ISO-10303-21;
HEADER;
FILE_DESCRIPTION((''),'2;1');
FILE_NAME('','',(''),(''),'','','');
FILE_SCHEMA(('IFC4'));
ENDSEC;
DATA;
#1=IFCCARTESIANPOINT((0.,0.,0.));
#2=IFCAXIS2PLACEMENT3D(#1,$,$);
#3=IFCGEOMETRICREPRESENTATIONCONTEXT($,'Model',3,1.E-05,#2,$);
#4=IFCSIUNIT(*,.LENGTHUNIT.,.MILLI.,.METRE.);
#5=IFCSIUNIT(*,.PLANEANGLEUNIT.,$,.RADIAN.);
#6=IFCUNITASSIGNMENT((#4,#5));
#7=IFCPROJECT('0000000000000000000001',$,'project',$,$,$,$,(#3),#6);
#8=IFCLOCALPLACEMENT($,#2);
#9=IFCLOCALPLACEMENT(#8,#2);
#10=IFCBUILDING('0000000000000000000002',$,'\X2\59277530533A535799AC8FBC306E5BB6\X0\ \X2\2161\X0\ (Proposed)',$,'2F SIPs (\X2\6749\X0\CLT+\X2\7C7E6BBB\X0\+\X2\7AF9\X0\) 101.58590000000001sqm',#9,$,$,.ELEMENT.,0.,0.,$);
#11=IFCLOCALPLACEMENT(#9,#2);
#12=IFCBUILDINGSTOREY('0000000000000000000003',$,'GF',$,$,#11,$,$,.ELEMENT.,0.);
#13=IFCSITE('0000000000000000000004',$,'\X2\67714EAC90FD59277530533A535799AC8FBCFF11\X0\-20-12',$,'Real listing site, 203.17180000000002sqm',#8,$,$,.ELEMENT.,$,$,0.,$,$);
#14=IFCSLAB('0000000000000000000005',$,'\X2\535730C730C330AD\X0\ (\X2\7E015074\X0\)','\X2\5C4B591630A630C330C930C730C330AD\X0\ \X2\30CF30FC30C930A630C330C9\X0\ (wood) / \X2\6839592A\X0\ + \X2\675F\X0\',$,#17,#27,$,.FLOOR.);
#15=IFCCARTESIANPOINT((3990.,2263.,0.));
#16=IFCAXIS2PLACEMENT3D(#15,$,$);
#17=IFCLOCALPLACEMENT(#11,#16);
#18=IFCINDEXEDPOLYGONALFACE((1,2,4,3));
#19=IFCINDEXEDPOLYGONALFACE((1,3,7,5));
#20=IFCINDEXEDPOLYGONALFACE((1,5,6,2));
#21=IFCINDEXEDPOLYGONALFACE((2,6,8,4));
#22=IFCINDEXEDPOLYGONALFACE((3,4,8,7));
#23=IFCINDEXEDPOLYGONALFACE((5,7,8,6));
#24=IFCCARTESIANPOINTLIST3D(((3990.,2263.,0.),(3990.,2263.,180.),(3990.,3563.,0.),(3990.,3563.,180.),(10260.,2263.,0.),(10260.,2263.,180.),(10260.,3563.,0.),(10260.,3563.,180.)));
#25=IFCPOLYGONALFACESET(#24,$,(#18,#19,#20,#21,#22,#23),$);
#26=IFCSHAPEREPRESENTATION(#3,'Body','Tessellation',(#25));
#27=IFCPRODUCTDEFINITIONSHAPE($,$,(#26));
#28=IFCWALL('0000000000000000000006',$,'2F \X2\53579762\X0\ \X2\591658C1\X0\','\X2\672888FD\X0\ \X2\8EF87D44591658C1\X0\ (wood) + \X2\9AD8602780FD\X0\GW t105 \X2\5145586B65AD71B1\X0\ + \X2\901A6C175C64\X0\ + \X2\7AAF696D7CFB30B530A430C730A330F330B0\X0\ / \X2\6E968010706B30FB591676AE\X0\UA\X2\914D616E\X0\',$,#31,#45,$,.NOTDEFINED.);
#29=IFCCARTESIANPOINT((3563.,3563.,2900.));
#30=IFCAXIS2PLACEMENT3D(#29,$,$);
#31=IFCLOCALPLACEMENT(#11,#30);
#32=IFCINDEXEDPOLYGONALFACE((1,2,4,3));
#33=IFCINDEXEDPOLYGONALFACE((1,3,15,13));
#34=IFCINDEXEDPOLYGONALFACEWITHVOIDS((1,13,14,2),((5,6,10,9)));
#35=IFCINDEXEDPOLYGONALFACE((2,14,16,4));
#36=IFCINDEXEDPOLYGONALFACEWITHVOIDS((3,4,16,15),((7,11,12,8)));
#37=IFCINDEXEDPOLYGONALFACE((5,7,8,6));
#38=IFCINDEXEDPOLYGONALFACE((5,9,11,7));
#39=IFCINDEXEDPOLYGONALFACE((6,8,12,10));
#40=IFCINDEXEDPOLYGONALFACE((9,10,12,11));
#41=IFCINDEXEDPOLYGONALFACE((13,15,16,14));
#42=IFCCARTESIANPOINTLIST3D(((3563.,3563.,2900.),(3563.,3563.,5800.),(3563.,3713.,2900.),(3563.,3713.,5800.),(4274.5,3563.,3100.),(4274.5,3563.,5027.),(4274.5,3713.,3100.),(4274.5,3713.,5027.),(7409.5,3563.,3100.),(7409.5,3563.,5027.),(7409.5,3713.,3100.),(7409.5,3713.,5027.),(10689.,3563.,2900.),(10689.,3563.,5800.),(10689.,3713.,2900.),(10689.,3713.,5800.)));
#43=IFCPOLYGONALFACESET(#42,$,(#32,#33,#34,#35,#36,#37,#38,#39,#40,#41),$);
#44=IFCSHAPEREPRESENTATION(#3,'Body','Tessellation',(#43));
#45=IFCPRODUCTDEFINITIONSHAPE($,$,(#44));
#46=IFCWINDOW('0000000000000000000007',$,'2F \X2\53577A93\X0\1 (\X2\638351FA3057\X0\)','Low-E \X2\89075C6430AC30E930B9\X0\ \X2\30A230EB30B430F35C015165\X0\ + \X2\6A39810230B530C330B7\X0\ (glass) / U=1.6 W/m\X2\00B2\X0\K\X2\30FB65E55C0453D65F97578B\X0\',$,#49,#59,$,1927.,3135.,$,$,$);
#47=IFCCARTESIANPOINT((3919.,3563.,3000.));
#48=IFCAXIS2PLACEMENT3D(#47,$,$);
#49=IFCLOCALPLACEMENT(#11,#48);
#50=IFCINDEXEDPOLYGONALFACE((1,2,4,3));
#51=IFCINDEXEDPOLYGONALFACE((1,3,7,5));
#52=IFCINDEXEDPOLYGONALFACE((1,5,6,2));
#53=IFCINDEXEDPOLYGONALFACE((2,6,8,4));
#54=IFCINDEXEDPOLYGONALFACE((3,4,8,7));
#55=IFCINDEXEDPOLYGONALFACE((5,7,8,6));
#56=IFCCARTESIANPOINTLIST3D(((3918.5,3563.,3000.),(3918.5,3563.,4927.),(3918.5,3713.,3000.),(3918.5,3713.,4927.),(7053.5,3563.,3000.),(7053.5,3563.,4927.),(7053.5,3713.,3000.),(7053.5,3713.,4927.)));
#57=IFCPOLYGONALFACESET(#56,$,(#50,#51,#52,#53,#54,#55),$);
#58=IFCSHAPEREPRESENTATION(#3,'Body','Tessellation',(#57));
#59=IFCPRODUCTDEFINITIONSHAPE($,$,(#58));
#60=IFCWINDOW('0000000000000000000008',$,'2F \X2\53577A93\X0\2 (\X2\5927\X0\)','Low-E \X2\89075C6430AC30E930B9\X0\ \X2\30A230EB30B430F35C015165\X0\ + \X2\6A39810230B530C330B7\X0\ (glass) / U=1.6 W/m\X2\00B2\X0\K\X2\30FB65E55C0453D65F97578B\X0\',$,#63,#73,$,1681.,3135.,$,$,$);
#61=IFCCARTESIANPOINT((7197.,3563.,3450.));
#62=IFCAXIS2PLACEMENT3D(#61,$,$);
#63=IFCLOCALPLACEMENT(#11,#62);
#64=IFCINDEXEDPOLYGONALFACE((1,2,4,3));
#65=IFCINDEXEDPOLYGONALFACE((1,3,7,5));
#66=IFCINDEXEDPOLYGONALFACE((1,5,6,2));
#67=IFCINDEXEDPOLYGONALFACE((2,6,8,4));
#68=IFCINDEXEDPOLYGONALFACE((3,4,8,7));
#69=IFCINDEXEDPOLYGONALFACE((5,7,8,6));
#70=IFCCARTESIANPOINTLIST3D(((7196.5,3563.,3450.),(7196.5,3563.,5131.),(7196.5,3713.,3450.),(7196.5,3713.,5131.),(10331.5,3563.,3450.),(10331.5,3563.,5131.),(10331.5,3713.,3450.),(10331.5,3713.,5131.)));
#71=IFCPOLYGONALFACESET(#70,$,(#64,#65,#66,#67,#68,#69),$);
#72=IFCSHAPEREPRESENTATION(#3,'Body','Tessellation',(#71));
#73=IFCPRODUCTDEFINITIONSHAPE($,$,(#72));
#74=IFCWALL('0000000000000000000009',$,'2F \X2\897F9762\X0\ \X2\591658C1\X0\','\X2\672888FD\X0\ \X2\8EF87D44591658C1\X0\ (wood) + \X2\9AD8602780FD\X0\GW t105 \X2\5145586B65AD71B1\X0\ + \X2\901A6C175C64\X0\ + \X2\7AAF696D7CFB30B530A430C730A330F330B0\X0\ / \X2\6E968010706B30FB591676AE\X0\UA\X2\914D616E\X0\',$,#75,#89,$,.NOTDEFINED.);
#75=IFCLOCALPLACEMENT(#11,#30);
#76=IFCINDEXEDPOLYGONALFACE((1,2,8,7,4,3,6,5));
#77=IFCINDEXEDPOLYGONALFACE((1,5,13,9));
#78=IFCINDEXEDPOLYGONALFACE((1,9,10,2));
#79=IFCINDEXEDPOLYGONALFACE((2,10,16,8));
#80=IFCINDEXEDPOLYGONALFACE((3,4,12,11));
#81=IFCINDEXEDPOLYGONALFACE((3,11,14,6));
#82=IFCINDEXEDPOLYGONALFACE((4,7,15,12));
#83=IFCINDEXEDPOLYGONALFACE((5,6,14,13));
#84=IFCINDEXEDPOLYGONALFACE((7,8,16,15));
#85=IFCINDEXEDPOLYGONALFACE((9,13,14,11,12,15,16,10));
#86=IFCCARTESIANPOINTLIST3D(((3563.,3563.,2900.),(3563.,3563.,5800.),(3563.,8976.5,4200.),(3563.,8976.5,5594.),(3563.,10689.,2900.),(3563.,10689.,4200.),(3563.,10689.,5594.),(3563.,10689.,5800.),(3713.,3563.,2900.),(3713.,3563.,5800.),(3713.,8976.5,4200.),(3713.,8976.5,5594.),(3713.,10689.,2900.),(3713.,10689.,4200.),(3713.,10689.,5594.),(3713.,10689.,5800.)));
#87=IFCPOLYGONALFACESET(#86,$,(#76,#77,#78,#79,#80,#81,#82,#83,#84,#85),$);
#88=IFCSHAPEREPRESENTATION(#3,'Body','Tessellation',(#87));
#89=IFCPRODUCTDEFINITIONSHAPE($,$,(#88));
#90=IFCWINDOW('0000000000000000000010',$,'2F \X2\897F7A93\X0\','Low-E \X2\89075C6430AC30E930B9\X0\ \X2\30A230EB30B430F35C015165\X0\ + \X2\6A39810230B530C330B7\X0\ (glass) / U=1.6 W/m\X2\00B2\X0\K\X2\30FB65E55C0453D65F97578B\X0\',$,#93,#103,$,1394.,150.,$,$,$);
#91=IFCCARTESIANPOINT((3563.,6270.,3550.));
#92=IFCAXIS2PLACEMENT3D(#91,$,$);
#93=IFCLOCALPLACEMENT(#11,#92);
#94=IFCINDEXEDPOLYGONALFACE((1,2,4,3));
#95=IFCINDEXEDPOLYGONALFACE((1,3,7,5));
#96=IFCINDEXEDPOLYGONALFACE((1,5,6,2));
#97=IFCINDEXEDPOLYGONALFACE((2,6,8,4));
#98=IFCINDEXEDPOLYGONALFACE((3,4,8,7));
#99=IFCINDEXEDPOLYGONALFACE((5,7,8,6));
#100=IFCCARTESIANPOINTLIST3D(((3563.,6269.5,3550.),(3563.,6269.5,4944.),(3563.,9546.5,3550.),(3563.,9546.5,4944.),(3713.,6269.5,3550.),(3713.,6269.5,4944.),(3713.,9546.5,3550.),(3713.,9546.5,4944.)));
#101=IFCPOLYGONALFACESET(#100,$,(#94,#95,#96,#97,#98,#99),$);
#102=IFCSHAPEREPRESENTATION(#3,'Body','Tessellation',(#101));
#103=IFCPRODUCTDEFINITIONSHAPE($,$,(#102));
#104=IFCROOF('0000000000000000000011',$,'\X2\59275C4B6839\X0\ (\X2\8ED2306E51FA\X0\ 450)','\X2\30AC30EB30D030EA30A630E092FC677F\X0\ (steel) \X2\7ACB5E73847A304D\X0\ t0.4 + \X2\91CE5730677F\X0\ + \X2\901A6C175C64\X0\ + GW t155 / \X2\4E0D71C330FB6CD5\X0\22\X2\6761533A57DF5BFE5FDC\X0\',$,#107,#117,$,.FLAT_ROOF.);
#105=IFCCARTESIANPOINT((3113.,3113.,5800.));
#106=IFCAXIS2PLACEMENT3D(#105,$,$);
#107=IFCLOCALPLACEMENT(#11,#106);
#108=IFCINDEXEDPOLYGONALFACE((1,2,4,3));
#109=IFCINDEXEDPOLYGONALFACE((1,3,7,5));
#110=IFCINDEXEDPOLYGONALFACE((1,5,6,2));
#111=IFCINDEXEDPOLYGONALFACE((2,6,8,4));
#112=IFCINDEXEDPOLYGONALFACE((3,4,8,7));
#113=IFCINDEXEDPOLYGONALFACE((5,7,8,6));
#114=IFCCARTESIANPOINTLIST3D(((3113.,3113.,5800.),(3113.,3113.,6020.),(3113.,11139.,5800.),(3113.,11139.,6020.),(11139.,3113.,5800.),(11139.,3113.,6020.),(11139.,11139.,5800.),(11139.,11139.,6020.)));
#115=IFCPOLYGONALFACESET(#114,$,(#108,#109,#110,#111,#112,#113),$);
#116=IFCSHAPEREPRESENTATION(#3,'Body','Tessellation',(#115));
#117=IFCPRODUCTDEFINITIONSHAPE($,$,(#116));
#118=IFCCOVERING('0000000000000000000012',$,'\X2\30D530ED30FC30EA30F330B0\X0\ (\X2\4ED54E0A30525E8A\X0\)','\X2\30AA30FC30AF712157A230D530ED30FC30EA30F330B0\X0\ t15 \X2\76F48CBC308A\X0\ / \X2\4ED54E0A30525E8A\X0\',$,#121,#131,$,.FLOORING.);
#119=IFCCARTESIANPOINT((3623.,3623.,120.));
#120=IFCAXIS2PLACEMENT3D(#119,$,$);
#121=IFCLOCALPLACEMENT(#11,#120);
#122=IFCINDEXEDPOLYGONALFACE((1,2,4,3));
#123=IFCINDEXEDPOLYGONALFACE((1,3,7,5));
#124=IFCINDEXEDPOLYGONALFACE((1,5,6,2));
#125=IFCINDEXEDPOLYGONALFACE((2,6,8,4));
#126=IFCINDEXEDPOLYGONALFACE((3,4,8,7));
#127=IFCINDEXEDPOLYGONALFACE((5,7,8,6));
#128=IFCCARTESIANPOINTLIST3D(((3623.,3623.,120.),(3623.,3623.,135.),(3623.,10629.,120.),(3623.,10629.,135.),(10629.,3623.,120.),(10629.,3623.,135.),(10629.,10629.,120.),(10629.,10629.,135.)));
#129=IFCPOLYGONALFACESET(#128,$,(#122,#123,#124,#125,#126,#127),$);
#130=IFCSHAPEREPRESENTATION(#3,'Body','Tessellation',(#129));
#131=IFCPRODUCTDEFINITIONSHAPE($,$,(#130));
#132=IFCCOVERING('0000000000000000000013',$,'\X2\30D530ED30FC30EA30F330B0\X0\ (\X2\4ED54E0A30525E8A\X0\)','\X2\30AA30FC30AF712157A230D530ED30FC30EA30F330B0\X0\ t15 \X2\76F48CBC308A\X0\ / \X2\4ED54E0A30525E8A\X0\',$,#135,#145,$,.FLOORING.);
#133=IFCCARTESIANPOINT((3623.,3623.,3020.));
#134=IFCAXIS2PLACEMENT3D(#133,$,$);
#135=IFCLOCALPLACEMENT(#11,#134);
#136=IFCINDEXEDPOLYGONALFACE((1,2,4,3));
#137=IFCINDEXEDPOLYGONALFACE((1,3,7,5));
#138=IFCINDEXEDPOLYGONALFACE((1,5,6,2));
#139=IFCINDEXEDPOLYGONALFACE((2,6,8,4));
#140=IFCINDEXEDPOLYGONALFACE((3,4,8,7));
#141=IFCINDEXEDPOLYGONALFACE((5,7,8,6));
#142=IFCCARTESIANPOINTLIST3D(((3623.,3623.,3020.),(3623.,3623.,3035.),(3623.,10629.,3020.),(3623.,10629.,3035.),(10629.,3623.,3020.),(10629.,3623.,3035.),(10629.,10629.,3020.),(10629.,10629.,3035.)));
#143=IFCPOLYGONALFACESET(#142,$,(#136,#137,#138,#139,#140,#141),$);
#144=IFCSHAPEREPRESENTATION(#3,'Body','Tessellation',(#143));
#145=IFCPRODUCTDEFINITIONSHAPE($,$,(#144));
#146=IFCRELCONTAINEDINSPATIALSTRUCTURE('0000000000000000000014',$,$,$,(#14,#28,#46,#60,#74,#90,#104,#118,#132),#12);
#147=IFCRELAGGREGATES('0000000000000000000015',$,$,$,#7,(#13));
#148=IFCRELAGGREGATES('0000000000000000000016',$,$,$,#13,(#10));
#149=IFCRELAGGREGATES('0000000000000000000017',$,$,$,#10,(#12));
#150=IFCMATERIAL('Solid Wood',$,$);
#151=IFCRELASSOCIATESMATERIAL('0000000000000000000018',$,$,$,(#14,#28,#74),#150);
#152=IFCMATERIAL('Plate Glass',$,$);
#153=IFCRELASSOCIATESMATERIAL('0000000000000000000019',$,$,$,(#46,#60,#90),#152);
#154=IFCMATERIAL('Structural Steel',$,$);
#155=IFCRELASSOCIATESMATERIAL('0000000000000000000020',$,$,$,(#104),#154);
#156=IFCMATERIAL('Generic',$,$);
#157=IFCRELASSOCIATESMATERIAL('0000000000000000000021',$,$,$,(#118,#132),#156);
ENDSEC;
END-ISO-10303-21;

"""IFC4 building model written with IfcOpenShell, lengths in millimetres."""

from ifc_helpers import new_model, si_unit, frame, frame_2d, origin, place, context, project, spatial, rectangle, extrude, material, element, fill, save


model = new_model("IFC4")

# Units and contexts
model_context = context("Model", 3, precision=1e-05, world=origin())
ifc_project = project(units=[si_unit("LENGTHUNIT", "METRE", prefix="MILLI"), si_unit("PLANEANGLEUNIT", "RADIAN")], contexts=[model_context])

# Site, building, storey
site_placement = place(None, origin())
site = spatial("IfcSite", under=ifc_project, at=site_placement, Name="東京都大田区南馬込１-20-12", ObjectType="Real listing site, 203.17180000000002sqm", CompositionType="ELEMENT", RefElevation=0.0)
building_placement = place(site_placement, origin())
building = spatial("IfcBuilding", under=site, at=building_placement, Name="大田区南馬込の家 Ⅱ (Proposed)", ObjectType="2F SIPs (杉CLT+籾殻+竹) 101.58590000000001sqm", CompositionType="ELEMENT", ElevationOfRefHeight=0.0, ElevationOfTerrain=0.0)
storey_placement = place(building_placement, origin())
storey = spatial("IfcBuildingStorey", under=building, at=storey_placement, Name="GF", CompositionType="ELEMENT", Elevation=0.0)

# Slab
ifc_material_1 = material(Name="Solid Wood")
slab_1_placement = place(storey_placement, frame((3990.0, 2263.0, 0.0)))
element("IfcSlab", 1, at=slab_1_placement, inside=storey, material=ifc_material_1, Name="南デッキ (縁側)", Description="屋外ウッドデッキ ハードウッド (wood) / 根太 + 束", PredefinedType="FLOOR", context=model_context, shape_type="SweptSolid", body=[
    extrude(rectangle(XDim=6270.0, YDim=1300.0, at=frame_2d((3135.0, 650.0))), frame((3990.0, 2263.0, 0.0)), (0.0, 0.0, 1.0), 180.0),
])

# Shared definitions
ifc_material_2 = material(Name="Plate Glass")

# Wall, openings, windows
wall_1_placement = place(storey_placement, frame((3563.0, 3563.0, 2900.0)))
wall_1 = element("IfcWall", 2, at=wall_1_placement, inside=storey, material=ifc_material_1, Name="2F 南面 外壁", Description="木製 軸組外壁 (wood) + 高性能GW t105 充填断熱 + 通気層 + 窯業系サイディング / 準耐火・外皮UA配慮", PredefinedType="NOTDEFINED", context=model_context, shape_type="SweptSolid", body=[
    extrude(rectangle(XDim=7126.0, YDim=150.0, at=frame_2d((3563.0, 75.0))), frame((3563.0, 3563.0, 2900.0)), (0.0, 0.0, 1.0), 2900.0),
])
opening_1_placement = place(storey_placement, frame((3919.0, 3563.0, 3000.0)))
opening_1 = element("IfcOpeningElement", 3, at=opening_1_placement, cuts=wall_1, PredefinedType="NOTDEFINED", context=model_context, shape_type="SweptSolid", body=[
    extrude(rectangle(XDim=3135.0, YDim=150.0, at=frame_2d((1567.0, 75.0))), frame((3919.0, 3563.0, 3000.0)), (0.0, 0.0, 1.0), 1927.0),
])
opening_2_placement = place(storey_placement, frame((7197.0, 3563.0, 3450.0)))
opening_2 = element("IfcOpeningElement", 4, at=opening_2_placement, cuts=wall_1, PredefinedType="NOTDEFINED", context=model_context, shape_type="SweptSolid", body=[
    extrude(rectangle(XDim=3135.0, YDim=150.0, at=frame_2d((1567.0, 75.0))), frame((7197.0, 3563.0, 3450.0)), (0.0, 0.0, 1.0), 1681.0),
])
window_1_placement = place(storey_placement, frame((3919.0, 3563.0, 3000.0)))
window_1 = element("IfcWindow", 5, at=window_1_placement, inside=storey, material=ifc_material_2, Name="2F 南窓1 (掃出し)", Description="Low-E 複層ガラス アルゴン封入 + 樹脂サッシ (glass) / U=1.6 W/m²K・日射取得型", OverallHeight=1927.0, OverallWidth=3135.0, context=model_context, shape_type="SweptSolid", body=[
    extrude(rectangle(XDim=3135.0, YDim=150.0, at=frame_2d((1567.0, 75.0))), frame((3919.0, 3563.0, 3000.0)), (0.0, 0.0, 1.0), 1927.0),
])
fill(opening_1, window_1)
window_2_placement = place(storey_placement, frame((7197.0, 3563.0, 3450.0)))
window_2 = element("IfcWindow", 6, at=window_2_placement, inside=storey, material=ifc_material_2, Name="2F 南窓2 (大)", Description="Low-E 複層ガラス アルゴン封入 + 樹脂サッシ (glass) / U=1.6 W/m²K・日射取得型", OverallHeight=1681.0, OverallWidth=3135.0, context=model_context, shape_type="SweptSolid", body=[
    extrude(rectangle(XDim=3135.0, YDim=150.0, at=frame_2d((1567.0, 75.0))), frame((7197.0, 3563.0, 3450.0)), (0.0, 0.0, 1.0), 1681.0),
])
fill(opening_2, window_2)

# Wall, opening, window
wall_2_placement = place(storey_placement, frame((3563.0, 3563.0, 2900.0)))
wall_2 = element("IfcWall", 7, at=wall_2_placement, inside=storey, material=ifc_material_1, Name="2F 西面 外壁", Description="木製 軸組外壁 (wood) + 高性能GW t105 充填断熱 + 通気層 + 窯業系サイディング / 準耐火・外皮UA配慮", PredefinedType="NOTDEFINED", context=model_context, shape_type="SweptSolid", body=[
    extrude(rectangle(XDim=150.0, YDim=7126.0, at=frame_2d((75.0, 3563.0))), frame((3563.0, 3563.0, 2900.0)), (0.0, 0.0, 1.0), 2900.0),
])
opening_3_placement = place(storey_placement, frame((3563.0, 6270.0, 3550.0)))
opening_3 = element("IfcOpeningElement", 8, at=opening_3_placement, cuts=wall_2, PredefinedType="NOTDEFINED", context=model_context, shape_type="SweptSolid", body=[
    extrude(rectangle(XDim=150.0, YDim=3277.0, at=frame_2d((75.0, 1638.0))), frame((3563.0, 6270.0, 3550.0)), (0.0, 0.0, 1.0), 1394.0),
])
window_3_placement = place(storey_placement, frame((3563.0, 6270.0, 3550.0)))
window_3 = element("IfcWindow", 9, at=window_3_placement, inside=storey, material=ifc_material_2, Name="2F 西窓", Description="Low-E 複層ガラス アルゴン封入 + 樹脂サッシ (glass) / U=1.6 W/m²K・日射取得型", OverallHeight=1394.0, OverallWidth=150.0, context=model_context, shape_type="SweptSolid", body=[
    extrude(rectangle(XDim=150.0, YDim=3277.0, at=frame_2d((75.0, 1638.0))), frame((3563.0, 6270.0, 3550.0)), (0.0, 0.0, 1.0), 1394.0),
])
fill(opening_3, window_3)

# Roof
ifc_material_3 = material(Name="Structural Steel")
roof_placement = place(storey_placement, frame((3113.0, 3113.0, 5800.0)))
element("IfcRoof", 10, at=roof_placement, inside=storey, material=ifc_material_3, Name="大屋根 (軒の出 450)", Description="ガルバリウム鋼板 (steel) 立平葺き t0.4 + 野地板 + 通気層 + GW t155 / 不燃・法22条区域対応", PredefinedType="FLAT_ROOF", context=model_context, shape_type="SweptSolid", body=[
    extrude(rectangle(XDim=8026.0, YDim=8026.0, at=frame_2d((4013.0, 4013.0))), frame((3113.0, 3113.0, 5800.0)), (0.0, 0.0, 1.0), 220.0),
])

# Coverings
ifc_material_4 = material(Name="Generic")
covering_1_placement = place(storey_placement, frame((3623.0, 3623.0, 120.0)))
element("IfcCovering", 11, at=covering_1_placement, inside=storey, material=ifc_material_4, Name="フローリング (仕上げ床)", Description="オーク無垢フローリング t15 直貼り / 仕上げ床", PredefinedType="FLOORING", context=model_context, shape_type="SweptSolid", body=[
    extrude(rectangle(XDim=7006.0, YDim=7006.0, at=frame_2d((3503.0, 3503.0))), frame((3623.0, 3623.0, 120.0)), (0.0, 0.0, 1.0), 15.0),
])
covering_2_placement = place(storey_placement, frame((3623.0, 3623.0, 3020.0)))
element("IfcCovering", 12, at=covering_2_placement, inside=storey, material=ifc_material_4, Name="フローリング (仕上げ床)", Description="オーク無垢フローリング t15 直貼り / 仕上げ床", PredefinedType="FLOORING", context=model_context, shape_type="SweptSolid", body=[
    extrude(rectangle(XDim=7006.0, YDim=7006.0, at=frame_2d((3503.0, 3503.0))), frame((3623.0, 3623.0, 3020.0)), (0.0, 0.0, 1.0), 15.0),
])

save(model, "model.ifc")
